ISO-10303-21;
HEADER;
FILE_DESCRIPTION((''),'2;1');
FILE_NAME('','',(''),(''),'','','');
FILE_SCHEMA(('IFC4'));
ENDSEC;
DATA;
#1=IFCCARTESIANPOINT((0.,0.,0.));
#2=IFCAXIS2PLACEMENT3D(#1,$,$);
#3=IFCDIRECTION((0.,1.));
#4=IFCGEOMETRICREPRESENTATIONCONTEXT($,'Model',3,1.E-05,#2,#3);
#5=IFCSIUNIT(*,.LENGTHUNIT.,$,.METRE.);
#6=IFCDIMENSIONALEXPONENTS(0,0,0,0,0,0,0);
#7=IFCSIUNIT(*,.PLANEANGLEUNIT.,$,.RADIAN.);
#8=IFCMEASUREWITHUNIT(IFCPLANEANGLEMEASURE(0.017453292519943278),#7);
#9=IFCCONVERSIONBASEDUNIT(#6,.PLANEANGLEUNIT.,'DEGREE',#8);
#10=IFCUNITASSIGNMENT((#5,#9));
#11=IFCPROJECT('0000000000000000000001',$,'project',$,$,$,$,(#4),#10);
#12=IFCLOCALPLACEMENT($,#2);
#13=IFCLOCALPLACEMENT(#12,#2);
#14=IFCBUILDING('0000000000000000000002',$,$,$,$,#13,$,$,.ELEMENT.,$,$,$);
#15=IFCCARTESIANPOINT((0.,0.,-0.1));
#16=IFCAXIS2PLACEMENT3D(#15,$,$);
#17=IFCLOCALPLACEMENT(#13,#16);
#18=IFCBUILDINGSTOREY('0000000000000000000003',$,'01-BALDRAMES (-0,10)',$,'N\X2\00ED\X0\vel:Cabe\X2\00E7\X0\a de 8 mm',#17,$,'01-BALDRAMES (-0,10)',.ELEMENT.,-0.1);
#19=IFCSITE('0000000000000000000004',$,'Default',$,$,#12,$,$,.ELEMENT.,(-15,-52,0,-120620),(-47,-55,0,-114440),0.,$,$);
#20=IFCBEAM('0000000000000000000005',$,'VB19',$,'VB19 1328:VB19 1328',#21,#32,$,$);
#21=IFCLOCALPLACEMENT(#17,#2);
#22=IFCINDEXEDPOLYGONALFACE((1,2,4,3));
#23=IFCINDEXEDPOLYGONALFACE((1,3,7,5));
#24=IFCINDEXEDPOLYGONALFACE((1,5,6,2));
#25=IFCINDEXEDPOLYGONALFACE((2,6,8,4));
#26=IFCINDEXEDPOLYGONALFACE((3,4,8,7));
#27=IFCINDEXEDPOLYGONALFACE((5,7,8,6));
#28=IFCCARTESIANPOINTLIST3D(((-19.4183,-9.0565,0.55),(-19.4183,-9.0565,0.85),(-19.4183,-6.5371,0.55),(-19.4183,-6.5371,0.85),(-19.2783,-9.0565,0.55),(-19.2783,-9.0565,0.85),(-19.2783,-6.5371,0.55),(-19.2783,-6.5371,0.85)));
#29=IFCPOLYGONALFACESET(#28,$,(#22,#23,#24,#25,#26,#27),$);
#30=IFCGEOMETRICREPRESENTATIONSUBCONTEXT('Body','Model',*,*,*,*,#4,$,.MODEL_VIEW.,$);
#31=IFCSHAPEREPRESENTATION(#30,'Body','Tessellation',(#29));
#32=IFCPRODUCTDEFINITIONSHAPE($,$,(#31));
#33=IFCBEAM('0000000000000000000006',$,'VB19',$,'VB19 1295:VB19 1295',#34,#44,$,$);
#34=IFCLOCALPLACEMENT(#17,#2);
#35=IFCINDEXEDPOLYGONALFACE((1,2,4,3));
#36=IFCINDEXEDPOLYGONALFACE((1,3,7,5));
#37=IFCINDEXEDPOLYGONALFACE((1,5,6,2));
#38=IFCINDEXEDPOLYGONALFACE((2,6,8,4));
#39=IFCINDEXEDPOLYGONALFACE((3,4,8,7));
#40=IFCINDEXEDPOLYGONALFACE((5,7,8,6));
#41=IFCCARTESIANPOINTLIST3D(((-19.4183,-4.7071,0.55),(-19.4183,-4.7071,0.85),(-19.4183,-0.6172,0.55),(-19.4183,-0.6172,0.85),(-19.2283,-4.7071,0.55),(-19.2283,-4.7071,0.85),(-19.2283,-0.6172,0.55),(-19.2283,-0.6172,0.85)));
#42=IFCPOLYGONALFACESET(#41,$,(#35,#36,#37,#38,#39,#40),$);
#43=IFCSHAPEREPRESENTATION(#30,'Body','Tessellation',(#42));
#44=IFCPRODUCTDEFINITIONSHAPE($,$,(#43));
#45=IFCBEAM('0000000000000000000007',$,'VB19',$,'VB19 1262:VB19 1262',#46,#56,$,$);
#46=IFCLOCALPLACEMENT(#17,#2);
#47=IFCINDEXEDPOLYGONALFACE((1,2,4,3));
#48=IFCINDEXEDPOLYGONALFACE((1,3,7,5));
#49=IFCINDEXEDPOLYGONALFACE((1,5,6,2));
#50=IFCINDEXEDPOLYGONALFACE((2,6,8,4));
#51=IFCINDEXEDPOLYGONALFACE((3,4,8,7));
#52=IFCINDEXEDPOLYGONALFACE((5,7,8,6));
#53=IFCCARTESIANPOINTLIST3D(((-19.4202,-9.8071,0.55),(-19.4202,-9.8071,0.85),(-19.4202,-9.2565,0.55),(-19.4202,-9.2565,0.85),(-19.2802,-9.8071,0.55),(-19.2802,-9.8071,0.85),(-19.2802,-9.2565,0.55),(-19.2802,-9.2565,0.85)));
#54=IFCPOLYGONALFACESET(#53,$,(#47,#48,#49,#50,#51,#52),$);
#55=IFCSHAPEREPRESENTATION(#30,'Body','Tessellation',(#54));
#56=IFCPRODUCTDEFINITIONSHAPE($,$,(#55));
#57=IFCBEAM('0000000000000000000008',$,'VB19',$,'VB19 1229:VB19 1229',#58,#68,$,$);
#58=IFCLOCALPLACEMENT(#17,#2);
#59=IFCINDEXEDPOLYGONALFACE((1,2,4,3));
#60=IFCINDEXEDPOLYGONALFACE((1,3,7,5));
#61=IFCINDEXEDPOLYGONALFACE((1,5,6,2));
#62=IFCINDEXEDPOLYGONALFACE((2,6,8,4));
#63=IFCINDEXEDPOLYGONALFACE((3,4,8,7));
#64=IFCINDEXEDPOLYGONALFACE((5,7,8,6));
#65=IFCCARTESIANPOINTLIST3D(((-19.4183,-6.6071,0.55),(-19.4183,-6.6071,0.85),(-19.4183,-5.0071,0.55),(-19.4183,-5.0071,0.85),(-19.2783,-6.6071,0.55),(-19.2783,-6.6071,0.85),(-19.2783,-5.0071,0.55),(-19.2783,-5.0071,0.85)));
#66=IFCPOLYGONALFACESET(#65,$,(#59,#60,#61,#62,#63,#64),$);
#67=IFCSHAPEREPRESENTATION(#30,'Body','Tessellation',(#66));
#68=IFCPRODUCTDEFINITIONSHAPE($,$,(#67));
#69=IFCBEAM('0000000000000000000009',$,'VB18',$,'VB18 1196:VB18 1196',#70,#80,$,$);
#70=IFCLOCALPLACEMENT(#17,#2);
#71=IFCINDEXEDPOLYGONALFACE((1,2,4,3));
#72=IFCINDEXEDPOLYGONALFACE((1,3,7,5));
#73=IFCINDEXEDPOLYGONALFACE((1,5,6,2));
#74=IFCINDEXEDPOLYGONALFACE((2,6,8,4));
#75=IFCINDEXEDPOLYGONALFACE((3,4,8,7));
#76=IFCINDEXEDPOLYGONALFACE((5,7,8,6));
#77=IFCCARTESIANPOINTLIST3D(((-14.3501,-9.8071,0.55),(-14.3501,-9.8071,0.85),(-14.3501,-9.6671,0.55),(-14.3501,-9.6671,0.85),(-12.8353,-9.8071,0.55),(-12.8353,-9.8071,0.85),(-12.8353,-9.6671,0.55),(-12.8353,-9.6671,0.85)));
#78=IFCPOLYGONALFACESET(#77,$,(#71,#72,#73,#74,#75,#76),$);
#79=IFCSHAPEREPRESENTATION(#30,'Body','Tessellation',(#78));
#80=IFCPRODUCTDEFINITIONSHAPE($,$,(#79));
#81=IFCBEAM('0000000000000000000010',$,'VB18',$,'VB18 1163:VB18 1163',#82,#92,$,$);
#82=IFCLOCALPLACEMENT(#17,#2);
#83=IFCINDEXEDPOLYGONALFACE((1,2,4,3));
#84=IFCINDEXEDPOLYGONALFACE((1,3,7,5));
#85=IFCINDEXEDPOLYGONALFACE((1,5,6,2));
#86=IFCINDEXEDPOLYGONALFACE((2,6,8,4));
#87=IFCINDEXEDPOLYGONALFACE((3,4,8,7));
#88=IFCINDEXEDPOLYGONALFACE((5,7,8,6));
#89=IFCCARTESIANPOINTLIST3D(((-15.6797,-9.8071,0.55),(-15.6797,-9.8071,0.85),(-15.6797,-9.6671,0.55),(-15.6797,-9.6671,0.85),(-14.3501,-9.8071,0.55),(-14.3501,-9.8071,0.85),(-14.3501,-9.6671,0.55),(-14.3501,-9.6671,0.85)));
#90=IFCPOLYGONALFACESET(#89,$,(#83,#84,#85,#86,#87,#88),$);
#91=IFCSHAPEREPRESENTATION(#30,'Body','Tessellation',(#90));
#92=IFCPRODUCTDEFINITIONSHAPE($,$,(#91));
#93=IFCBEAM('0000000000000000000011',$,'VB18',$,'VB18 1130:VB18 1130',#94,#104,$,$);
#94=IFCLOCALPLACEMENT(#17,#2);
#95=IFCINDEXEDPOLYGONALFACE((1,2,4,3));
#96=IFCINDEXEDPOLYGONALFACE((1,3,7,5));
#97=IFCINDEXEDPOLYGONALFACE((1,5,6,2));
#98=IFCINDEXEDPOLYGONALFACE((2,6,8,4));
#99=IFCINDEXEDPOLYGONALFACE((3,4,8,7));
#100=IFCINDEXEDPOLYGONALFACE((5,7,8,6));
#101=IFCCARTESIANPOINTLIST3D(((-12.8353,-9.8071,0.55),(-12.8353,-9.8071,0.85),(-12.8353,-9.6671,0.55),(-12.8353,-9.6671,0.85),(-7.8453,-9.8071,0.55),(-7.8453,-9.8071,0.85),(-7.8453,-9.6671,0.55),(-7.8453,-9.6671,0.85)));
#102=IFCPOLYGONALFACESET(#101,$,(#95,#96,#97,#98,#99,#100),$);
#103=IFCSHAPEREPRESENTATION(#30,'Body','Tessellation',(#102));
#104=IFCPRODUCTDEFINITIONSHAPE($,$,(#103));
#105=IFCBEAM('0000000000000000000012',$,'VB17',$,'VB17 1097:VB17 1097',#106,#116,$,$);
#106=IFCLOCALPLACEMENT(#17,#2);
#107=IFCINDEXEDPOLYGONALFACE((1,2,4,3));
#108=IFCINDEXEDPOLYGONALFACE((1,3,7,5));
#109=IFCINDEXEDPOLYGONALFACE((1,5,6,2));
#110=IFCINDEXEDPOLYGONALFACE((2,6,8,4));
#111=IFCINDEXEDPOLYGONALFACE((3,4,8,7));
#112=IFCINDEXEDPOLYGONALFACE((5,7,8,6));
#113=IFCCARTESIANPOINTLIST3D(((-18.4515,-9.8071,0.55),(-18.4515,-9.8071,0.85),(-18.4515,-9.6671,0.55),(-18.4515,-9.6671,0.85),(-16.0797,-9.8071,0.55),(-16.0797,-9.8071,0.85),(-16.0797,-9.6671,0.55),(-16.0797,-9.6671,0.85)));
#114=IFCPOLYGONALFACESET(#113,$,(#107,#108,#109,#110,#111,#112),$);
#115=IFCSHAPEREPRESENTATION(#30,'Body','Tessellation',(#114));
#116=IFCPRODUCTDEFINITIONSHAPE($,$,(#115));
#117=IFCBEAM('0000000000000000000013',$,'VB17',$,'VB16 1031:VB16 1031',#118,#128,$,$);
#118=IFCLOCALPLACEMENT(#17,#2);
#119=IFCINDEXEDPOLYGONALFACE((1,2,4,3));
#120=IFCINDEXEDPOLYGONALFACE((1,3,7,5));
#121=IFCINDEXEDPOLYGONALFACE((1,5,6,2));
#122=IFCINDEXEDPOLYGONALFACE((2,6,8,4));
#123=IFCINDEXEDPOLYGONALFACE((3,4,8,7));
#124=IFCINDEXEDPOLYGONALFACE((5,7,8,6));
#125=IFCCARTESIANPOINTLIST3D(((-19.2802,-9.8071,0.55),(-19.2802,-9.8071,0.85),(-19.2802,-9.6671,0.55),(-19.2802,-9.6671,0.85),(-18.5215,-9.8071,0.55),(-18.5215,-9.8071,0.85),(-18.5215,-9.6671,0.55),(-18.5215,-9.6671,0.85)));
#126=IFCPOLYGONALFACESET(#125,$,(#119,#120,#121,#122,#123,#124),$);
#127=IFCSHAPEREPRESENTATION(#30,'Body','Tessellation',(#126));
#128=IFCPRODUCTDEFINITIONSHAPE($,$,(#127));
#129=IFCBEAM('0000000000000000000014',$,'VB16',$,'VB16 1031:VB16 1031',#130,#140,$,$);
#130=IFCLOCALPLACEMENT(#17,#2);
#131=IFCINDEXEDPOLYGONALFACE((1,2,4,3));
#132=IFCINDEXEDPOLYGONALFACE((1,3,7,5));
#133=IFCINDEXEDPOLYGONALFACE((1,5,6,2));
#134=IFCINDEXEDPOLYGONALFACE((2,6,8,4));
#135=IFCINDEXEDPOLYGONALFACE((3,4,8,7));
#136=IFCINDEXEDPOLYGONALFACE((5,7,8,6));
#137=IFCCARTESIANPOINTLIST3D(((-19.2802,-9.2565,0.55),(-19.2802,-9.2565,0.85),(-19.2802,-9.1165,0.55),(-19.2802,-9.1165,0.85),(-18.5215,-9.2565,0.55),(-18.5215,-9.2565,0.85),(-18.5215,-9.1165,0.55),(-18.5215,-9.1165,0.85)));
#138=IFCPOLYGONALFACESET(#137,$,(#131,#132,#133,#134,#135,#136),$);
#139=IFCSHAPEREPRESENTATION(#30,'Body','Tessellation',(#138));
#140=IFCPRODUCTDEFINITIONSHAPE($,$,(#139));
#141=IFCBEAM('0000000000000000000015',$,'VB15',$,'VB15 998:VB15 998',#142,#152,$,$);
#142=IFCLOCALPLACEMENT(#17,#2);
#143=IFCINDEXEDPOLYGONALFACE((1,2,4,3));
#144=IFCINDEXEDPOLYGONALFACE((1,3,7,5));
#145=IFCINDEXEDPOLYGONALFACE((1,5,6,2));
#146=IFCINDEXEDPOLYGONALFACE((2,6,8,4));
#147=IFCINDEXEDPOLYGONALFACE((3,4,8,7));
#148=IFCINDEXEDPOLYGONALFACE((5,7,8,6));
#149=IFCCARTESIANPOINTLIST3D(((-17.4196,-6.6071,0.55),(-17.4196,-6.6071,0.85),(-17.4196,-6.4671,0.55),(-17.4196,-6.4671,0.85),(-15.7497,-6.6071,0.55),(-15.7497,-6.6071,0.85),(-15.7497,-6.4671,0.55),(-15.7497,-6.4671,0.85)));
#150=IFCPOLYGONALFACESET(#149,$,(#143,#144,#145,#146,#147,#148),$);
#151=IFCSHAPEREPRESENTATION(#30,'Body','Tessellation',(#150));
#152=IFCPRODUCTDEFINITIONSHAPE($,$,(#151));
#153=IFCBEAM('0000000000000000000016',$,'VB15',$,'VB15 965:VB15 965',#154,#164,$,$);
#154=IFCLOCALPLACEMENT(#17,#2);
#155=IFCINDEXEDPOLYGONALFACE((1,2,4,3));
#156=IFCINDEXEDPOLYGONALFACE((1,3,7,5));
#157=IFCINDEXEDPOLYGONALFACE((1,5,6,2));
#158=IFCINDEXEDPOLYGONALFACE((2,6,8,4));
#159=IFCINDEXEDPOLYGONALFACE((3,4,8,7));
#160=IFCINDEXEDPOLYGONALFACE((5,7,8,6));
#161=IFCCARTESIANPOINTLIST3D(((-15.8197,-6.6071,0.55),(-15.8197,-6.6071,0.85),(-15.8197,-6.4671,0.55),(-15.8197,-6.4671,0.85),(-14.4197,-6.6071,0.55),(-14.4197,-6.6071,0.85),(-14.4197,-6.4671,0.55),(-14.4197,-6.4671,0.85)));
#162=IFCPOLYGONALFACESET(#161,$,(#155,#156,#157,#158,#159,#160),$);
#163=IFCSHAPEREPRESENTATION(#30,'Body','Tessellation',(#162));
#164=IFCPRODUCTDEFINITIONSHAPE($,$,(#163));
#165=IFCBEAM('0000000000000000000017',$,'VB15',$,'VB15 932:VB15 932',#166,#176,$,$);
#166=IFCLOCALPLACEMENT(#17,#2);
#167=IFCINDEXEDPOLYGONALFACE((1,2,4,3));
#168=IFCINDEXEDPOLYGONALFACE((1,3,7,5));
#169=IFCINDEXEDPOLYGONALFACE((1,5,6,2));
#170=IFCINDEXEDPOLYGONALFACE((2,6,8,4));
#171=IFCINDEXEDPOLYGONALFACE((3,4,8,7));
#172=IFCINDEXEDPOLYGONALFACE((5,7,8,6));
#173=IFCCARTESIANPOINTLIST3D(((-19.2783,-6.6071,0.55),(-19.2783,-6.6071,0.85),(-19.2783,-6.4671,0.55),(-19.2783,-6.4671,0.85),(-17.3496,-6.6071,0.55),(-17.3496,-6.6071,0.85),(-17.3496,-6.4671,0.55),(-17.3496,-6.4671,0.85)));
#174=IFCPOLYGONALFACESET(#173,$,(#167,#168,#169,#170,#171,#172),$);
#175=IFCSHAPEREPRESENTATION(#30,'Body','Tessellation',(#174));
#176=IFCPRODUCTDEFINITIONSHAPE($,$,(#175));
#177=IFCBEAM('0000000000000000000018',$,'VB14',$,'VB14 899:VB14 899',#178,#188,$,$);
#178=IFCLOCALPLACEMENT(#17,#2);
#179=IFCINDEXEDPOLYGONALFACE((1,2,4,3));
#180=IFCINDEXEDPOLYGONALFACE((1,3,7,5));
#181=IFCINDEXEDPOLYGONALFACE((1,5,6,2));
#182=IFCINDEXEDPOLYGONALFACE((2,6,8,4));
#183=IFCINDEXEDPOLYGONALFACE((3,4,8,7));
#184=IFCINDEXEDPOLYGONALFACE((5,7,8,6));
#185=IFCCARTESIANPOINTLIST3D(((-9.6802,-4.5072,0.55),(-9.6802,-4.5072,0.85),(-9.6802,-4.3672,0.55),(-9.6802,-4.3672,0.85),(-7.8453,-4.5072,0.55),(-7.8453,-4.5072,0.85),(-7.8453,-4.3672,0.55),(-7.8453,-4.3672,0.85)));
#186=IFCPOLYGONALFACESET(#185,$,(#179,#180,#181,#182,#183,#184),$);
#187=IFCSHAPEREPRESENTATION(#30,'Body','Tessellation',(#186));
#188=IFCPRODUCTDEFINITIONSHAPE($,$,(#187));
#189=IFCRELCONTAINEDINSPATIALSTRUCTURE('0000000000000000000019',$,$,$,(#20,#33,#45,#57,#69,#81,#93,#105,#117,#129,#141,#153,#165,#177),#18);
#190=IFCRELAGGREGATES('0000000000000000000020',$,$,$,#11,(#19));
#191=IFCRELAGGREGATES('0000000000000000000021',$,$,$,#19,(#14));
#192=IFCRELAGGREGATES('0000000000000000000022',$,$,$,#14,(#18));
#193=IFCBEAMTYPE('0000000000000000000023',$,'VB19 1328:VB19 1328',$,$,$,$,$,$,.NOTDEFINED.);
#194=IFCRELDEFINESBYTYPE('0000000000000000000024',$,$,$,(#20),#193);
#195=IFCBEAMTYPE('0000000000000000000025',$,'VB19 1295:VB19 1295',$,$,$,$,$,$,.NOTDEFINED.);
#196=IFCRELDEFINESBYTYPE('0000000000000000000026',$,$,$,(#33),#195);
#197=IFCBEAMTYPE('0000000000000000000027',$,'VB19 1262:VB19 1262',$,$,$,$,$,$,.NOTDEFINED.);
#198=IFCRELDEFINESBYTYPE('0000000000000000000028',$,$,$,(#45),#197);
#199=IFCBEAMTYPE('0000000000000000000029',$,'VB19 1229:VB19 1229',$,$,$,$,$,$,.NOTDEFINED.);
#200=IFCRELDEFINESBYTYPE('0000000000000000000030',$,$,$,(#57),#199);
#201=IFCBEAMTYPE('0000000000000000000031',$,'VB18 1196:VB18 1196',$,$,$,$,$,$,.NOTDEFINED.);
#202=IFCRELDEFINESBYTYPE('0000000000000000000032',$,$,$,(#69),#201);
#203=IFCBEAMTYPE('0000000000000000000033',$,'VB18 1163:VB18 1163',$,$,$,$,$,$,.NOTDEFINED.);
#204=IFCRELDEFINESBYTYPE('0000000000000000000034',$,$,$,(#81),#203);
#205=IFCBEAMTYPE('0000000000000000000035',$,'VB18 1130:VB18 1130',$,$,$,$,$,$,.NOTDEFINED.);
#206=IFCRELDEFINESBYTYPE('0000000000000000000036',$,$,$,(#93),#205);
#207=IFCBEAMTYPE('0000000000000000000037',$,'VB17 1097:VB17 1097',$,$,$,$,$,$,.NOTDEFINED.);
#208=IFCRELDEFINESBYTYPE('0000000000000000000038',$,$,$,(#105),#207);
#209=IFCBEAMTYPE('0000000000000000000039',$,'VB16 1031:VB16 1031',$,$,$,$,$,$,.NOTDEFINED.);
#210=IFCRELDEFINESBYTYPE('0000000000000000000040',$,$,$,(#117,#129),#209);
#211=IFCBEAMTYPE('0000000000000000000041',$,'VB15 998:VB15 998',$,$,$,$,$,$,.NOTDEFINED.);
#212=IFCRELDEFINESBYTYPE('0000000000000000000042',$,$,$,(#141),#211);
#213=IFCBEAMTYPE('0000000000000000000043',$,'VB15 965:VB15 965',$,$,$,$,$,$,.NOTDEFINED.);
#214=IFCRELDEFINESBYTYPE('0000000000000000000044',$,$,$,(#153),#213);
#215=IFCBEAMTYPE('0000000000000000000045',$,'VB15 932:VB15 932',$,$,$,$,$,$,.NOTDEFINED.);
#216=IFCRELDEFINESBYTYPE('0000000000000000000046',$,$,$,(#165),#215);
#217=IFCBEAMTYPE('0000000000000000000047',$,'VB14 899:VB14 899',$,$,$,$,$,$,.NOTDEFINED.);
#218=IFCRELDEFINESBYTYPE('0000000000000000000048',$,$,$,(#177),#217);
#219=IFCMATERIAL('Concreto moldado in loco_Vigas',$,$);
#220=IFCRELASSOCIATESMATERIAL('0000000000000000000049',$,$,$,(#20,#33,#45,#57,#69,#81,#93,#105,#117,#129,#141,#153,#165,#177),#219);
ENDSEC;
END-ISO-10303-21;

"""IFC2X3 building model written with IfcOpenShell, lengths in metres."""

from ifc_helpers import new_model, entity, si_unit, converted_unit, direction, frame, frame_2d, origin, place, context, subcontext, project, spatial, rectangle, extrude, material, type_object, element, save


model = new_model("IFC2X3")

# Units and contexts
model_context = context("Model", 3, precision=1e-05, world=origin(), true_north=direction((0.0, 1.0)))
body_context = subcontext(model_context, "Body", "Model", "MODEL_VIEW")
ifc_project = project(units=[si_unit("LENGTHUNIT", "METRE"), converted_unit("PLANEANGLEUNIT", "DEGREE", entity("IfcPlaneAngleMeasure", 0.017453292519943278), si_unit("PLANEANGLEUNIT", "RADIAN"), dimensions=[0, 0, 0, 0, 0, 0, 0])], contexts=[model_context])

# Site, building, storey
site_placement = place(None, origin())
site = spatial("IfcSite", under=ifc_project, at=site_placement, Name="Default", CompositionType="ELEMENT", RefLatitude=(-15, -52, 0, -120620), RefLongitude=(-47, -55, 0, -114440), RefElevation=0.0)
building_placement = place(site_placement, origin())
building = spatial("IfcBuilding", under=site, at=building_placement, CompositionType="ELEMENT")
storey_placement = place(building_placement, frame((0.0, 0.0, -0.1)))
storey = spatial("IfcBuildingStorey", under=building, at=storey_placement, Name="01-BALDRAMES (-0,10)", ObjectType="Nível:Cabeça de 8 mm", LongName="01-BALDRAMES (-0,10)", CompositionType="ELEMENT", Elevation=-0.1)

# Beams
ifc_material = material(Name="Concreto moldado in loco_Vigas")
beam_type_1 = type_object("IfcBeamType", Name="VB19 1328:VB19 1328", PredefinedType="NOTDEFINED")
beam_1_placement = place(storey_placement, origin())
element("IfcBeam", 1, at=beam_1_placement, inside=storey, type_object=beam_type_1, material=ifc_material, Name="VB19", ObjectType="VB19 1328:VB19 1328", context=body_context, shape_type="SweptSolid", body=[
    extrude(rectangle(XDim=0.3, YDim=2.5194, at=frame_2d((0.0, 0.0), x_axis=(0.0, 1.0))), frame((-19.4183, -7.7968, 0.7), z_axis=(1.0, 0.0, 0.0), x_axis=(0.0, -1.0, 0.0)), (0.0, 0.0, 1.0), 0.14),
])
beam_type_2 = type_object("IfcBeamType", Name="VB19 1295:VB19 1295", PredefinedType="NOTDEFINED")
beam_2_placement = place(storey_placement, origin())
element("IfcBeam", 2, at=beam_2_placement, inside=storey, type_object=beam_type_2, material=ifc_material, Name="VB19", ObjectType="VB19 1295:VB19 1295", context=body_context, shape_type="SweptSolid", body=[
    extrude(rectangle(XDim=0.3, YDim=4.0899, at=frame_2d((0.0, 0.0), x_axis=(0.0, 1.0))), frame((-19.4183, -2.6621, 0.7), z_axis=(1.0, 0.0, 0.0), x_axis=(0.0, -1.0, 0.0)), (0.0, 0.0, 1.0), 0.19),
])
beam_type_3 = type_object("IfcBeamType", Name="VB19 1262:VB19 1262", PredefinedType="NOTDEFINED")
beam_3_placement = place(storey_placement, origin())
element("IfcBeam", 3, at=beam_3_placement, inside=storey, type_object=beam_type_3, material=ifc_material, Name="VB19", ObjectType="VB19 1262:VB19 1262", context=body_context, shape_type="SweptSolid", body=[
    extrude(rectangle(XDim=0.3, YDim=0.5506, at=frame_2d((0.0, 0.0), x_axis=(0.0, 1.0))), frame((-19.4202, -9.5318, 0.7), z_axis=(1.0, 0.0, 0.0), x_axis=(0.0, -1.0, 0.0)), (0.0, 0.0, 1.0), 0.14),
])
beam_type_4 = type_object("IfcBeamType", Name="VB19 1229:VB19 1229", PredefinedType="NOTDEFINED")
beam_4_placement = place(storey_placement, origin())
element("IfcBeam", 4, at=beam_4_placement, inside=storey, type_object=beam_type_4, material=ifc_material, Name="VB19", ObjectType="VB19 1229:VB19 1229", context=body_context, shape_type="SweptSolid", body=[
    extrude(rectangle(XDim=0.3, YDim=1.6, at=frame_2d((0.0, 0.0), x_axis=(0.0, 1.0))), frame((-19.4183, -5.8071, 0.7), z_axis=(1.0, 0.0, 0.0), x_axis=(0.0, -1.0, 0.0)), (0.0, 0.0, 1.0), 0.14),
])
beam_type_5 = type_object("IfcBeamType", Name="VB18 1196:VB18 1196", PredefinedType="NOTDEFINED")
beam_5_placement = place(storey_placement, origin())
element("IfcBeam", 5, at=beam_5_placement, inside=storey, type_object=beam_type_5, material=ifc_material, Name="VB18", ObjectType="VB18 1196:VB18 1196", context=body_context, shape_type="SweptSolid", body=[
    extrude(rectangle(XDim=0.3, YDim=0.14, at=frame_2d((0.0, 0.0), x_axis=(1.0, 0.0))), frame((-14.3501, -9.7371, 0.7), z_axis=(1.0, 0.0, 0.0), x_axis=(0.0, 0.0, -1.0)), (0.0, 0.0, 1.0), 1.5148),
])
beam_type_6 = type_object("IfcBeamType", Name="VB18 1163:VB18 1163", PredefinedType="NOTDEFINED")
beam_6_placement = place(storey_placement, origin())
element("IfcBeam", 6, at=beam_6_placement, inside=storey, type_object=beam_type_6, material=ifc_material, Name="VB18", ObjectType="VB18 1163:VB18 1163", context=body_context, shape_type="SweptSolid", body=[
    extrude(rectangle(XDim=0.3, YDim=0.14, at=frame_2d((0.0, 0.0), x_axis=(1.0, 0.0))), frame((-15.6797, -9.7371, 0.7), z_axis=(1.0, 0.0, 0.0), x_axis=(0.0, 0.0, -1.0)), (0.0, 0.0, 1.0), 1.3296),
])
beam_type_7 = type_object("IfcBeamType", Name="VB18 1130:VB18 1130", PredefinedType="NOTDEFINED")
beam_7_placement = place(storey_placement, origin())
element("IfcBeam", 7, at=beam_7_placement, inside=storey, type_object=beam_type_7, material=ifc_material, Name="VB18", ObjectType="VB18 1130:VB18 1130", context=body_context, shape_type="SweptSolid", body=[
    extrude(rectangle(XDim=0.3, YDim=0.14, at=frame_2d((0.0, 0.0), x_axis=(1.0, 0.0))), frame((-12.8353, -9.7371, 0.7), z_axis=(1.0, 0.0, 0.0), x_axis=(0.0, 0.0, -1.0)), (0.0, 0.0, 1.0), 4.99),
])
beam_type_8 = type_object("IfcBeamType", Name="VB17 1097:VB17 1097", PredefinedType="NOTDEFINED")
beam_8_placement = place(storey_placement, origin())
element("IfcBeam", 8, at=beam_8_placement, inside=storey, type_object=beam_type_8, material=ifc_material, Name="VB17", ObjectType="VB17 1097:VB17 1097", context=body_context, shape_type="SweptSolid", body=[
    extrude(rectangle(XDim=0.3, YDim=0.14, at=frame_2d((0.0, 0.0), x_axis=(1.0, 0.0))), frame((-18.4515, -9.7371, 0.7), z_axis=(1.0, 0.0, 0.0), x_axis=(0.0, 0.0, -1.0)), (0.0, 0.0, 1.0), 2.3718),
])
beam_type_9 = type_object("IfcBeamType", Name="VB16 1031:VB16 1031", PredefinedType="NOTDEFINED")
beam_9_placement = place(storey_placement, origin())
element("IfcBeam", 9, at=beam_9_placement, inside=storey, type_object=beam_type_9, material=ifc_material, Name="VB17", ObjectType="VB16 1031:VB16 1031", context=body_context, shape_type="SweptSolid", body=[
    extrude(rectangle(XDim=0.3, YDim=0.14, at=frame_2d((0.0, 0.0), x_axis=(1.0, 0.0))), frame((-19.2802, -9.7371, 0.7), z_axis=(1.0, 0.0, 0.0), x_axis=(0.0, 0.0, -1.0)), (0.0, 0.0, 1.0), 0.7587),
])
beam_10_placement = place(storey_placement, origin())
element("IfcBeam", 10, at=beam_10_placement, inside=storey, type_object=beam_type_9, material=ifc_material, Name="VB16", ObjectType="VB16 1031:VB16 1031", context=body_context, shape_type="SweptSolid", body=[
    extrude(rectangle(XDim=0.3, YDim=0.14, at=frame_2d((0.0, 0.0), x_axis=(1.0, 0.0))), frame((-19.2802, -9.1865, 0.7), z_axis=(1.0, 0.0, 0.0), x_axis=(0.0, 0.0, -1.0)), (0.0, 0.0, 1.0), 0.7587),
])
beam_type_10 = type_object("IfcBeamType", Name="VB15 998:VB15 998", PredefinedType="NOTDEFINED")
beam_11_placement = place(storey_placement, origin())
element("IfcBeam", 11, at=beam_11_placement, inside=storey, type_object=beam_type_10, material=ifc_material, Name="VB15", ObjectType="VB15 998:VB15 998", context=body_context, shape_type="SweptSolid", body=[
    extrude(rectangle(XDim=0.3, YDim=0.14, at=frame_2d((0.0, 0.0), x_axis=(1.0, 0.0))), frame((-17.4196, -6.5371, 0.7), z_axis=(1.0, 0.0, 0.0), x_axis=(0.0, 0.0, -1.0)), (0.0, 0.0, 1.0), 1.6699),
])
beam_type_11 = type_object("IfcBeamType", Name="VB15 965:VB15 965", PredefinedType="NOTDEFINED")
beam_12_placement = place(storey_placement, origin())
element("IfcBeam", 12, at=beam_12_placement, inside=storey, type_object=beam_type_11, material=ifc_material, Name="VB15", ObjectType="VB15 965:VB15 965", context=body_context, shape_type="SweptSolid", body=[
    extrude(rectangle(XDim=0.3, YDim=0.14, at=frame_2d((0.0, 0.0), x_axis=(1.0, 0.0))), frame((-15.8197, -6.5371, 0.7), z_axis=(1.0, 0.0, 0.0), x_axis=(0.0, 0.0, -1.0)), (0.0, 0.0, 1.0), 1.4),
])
beam_type_12 = type_object("IfcBeamType", Name="VB15 932:VB15 932", PredefinedType="NOTDEFINED")
beam_13_placement = place(storey_placement, origin())
element("IfcBeam", 13, at=beam_13_placement, inside=storey, type_object=beam_type_12, material=ifc_material, Name="VB15", ObjectType="VB15 932:VB15 932", context=body_context, shape_type="SweptSolid", body=[
    extrude(rectangle(XDim=0.3, YDim=0.14, at=frame_2d((0.0, 0.0), x_axis=(1.0, 0.0))), frame((-19.2783, -6.5371, 0.7), z_axis=(1.0, 0.0, 0.0), x_axis=(0.0, 0.0, -1.0)), (0.0, 0.0, 1.0), 1.9287),
])
beam_type_13 = type_object("IfcBeamType", Name="VB14 899:VB14 899", PredefinedType="NOTDEFINED")
beam_14_placement = place(storey_placement, origin())
element("IfcBeam", 14, at=beam_14_placement, inside=storey, type_object=beam_type_13, material=ifc_material, Name="VB14", ObjectType="VB14 899:VB14 899", context=body_context, shape_type="SweptSolid", body=[
    extrude(rectangle(XDim=0.3, YDim=0.14, at=frame_2d((0.0, 0.0), x_axis=(1.0, 0.0))), frame((-9.6802, -4.4372, 0.7), z_axis=(1.0, 0.0, 0.0), x_axis=(0.0, 0.0, -1.0)), (0.0, 0.0, 1.0), 1.8349),
])

save(model, "model.ifc")
